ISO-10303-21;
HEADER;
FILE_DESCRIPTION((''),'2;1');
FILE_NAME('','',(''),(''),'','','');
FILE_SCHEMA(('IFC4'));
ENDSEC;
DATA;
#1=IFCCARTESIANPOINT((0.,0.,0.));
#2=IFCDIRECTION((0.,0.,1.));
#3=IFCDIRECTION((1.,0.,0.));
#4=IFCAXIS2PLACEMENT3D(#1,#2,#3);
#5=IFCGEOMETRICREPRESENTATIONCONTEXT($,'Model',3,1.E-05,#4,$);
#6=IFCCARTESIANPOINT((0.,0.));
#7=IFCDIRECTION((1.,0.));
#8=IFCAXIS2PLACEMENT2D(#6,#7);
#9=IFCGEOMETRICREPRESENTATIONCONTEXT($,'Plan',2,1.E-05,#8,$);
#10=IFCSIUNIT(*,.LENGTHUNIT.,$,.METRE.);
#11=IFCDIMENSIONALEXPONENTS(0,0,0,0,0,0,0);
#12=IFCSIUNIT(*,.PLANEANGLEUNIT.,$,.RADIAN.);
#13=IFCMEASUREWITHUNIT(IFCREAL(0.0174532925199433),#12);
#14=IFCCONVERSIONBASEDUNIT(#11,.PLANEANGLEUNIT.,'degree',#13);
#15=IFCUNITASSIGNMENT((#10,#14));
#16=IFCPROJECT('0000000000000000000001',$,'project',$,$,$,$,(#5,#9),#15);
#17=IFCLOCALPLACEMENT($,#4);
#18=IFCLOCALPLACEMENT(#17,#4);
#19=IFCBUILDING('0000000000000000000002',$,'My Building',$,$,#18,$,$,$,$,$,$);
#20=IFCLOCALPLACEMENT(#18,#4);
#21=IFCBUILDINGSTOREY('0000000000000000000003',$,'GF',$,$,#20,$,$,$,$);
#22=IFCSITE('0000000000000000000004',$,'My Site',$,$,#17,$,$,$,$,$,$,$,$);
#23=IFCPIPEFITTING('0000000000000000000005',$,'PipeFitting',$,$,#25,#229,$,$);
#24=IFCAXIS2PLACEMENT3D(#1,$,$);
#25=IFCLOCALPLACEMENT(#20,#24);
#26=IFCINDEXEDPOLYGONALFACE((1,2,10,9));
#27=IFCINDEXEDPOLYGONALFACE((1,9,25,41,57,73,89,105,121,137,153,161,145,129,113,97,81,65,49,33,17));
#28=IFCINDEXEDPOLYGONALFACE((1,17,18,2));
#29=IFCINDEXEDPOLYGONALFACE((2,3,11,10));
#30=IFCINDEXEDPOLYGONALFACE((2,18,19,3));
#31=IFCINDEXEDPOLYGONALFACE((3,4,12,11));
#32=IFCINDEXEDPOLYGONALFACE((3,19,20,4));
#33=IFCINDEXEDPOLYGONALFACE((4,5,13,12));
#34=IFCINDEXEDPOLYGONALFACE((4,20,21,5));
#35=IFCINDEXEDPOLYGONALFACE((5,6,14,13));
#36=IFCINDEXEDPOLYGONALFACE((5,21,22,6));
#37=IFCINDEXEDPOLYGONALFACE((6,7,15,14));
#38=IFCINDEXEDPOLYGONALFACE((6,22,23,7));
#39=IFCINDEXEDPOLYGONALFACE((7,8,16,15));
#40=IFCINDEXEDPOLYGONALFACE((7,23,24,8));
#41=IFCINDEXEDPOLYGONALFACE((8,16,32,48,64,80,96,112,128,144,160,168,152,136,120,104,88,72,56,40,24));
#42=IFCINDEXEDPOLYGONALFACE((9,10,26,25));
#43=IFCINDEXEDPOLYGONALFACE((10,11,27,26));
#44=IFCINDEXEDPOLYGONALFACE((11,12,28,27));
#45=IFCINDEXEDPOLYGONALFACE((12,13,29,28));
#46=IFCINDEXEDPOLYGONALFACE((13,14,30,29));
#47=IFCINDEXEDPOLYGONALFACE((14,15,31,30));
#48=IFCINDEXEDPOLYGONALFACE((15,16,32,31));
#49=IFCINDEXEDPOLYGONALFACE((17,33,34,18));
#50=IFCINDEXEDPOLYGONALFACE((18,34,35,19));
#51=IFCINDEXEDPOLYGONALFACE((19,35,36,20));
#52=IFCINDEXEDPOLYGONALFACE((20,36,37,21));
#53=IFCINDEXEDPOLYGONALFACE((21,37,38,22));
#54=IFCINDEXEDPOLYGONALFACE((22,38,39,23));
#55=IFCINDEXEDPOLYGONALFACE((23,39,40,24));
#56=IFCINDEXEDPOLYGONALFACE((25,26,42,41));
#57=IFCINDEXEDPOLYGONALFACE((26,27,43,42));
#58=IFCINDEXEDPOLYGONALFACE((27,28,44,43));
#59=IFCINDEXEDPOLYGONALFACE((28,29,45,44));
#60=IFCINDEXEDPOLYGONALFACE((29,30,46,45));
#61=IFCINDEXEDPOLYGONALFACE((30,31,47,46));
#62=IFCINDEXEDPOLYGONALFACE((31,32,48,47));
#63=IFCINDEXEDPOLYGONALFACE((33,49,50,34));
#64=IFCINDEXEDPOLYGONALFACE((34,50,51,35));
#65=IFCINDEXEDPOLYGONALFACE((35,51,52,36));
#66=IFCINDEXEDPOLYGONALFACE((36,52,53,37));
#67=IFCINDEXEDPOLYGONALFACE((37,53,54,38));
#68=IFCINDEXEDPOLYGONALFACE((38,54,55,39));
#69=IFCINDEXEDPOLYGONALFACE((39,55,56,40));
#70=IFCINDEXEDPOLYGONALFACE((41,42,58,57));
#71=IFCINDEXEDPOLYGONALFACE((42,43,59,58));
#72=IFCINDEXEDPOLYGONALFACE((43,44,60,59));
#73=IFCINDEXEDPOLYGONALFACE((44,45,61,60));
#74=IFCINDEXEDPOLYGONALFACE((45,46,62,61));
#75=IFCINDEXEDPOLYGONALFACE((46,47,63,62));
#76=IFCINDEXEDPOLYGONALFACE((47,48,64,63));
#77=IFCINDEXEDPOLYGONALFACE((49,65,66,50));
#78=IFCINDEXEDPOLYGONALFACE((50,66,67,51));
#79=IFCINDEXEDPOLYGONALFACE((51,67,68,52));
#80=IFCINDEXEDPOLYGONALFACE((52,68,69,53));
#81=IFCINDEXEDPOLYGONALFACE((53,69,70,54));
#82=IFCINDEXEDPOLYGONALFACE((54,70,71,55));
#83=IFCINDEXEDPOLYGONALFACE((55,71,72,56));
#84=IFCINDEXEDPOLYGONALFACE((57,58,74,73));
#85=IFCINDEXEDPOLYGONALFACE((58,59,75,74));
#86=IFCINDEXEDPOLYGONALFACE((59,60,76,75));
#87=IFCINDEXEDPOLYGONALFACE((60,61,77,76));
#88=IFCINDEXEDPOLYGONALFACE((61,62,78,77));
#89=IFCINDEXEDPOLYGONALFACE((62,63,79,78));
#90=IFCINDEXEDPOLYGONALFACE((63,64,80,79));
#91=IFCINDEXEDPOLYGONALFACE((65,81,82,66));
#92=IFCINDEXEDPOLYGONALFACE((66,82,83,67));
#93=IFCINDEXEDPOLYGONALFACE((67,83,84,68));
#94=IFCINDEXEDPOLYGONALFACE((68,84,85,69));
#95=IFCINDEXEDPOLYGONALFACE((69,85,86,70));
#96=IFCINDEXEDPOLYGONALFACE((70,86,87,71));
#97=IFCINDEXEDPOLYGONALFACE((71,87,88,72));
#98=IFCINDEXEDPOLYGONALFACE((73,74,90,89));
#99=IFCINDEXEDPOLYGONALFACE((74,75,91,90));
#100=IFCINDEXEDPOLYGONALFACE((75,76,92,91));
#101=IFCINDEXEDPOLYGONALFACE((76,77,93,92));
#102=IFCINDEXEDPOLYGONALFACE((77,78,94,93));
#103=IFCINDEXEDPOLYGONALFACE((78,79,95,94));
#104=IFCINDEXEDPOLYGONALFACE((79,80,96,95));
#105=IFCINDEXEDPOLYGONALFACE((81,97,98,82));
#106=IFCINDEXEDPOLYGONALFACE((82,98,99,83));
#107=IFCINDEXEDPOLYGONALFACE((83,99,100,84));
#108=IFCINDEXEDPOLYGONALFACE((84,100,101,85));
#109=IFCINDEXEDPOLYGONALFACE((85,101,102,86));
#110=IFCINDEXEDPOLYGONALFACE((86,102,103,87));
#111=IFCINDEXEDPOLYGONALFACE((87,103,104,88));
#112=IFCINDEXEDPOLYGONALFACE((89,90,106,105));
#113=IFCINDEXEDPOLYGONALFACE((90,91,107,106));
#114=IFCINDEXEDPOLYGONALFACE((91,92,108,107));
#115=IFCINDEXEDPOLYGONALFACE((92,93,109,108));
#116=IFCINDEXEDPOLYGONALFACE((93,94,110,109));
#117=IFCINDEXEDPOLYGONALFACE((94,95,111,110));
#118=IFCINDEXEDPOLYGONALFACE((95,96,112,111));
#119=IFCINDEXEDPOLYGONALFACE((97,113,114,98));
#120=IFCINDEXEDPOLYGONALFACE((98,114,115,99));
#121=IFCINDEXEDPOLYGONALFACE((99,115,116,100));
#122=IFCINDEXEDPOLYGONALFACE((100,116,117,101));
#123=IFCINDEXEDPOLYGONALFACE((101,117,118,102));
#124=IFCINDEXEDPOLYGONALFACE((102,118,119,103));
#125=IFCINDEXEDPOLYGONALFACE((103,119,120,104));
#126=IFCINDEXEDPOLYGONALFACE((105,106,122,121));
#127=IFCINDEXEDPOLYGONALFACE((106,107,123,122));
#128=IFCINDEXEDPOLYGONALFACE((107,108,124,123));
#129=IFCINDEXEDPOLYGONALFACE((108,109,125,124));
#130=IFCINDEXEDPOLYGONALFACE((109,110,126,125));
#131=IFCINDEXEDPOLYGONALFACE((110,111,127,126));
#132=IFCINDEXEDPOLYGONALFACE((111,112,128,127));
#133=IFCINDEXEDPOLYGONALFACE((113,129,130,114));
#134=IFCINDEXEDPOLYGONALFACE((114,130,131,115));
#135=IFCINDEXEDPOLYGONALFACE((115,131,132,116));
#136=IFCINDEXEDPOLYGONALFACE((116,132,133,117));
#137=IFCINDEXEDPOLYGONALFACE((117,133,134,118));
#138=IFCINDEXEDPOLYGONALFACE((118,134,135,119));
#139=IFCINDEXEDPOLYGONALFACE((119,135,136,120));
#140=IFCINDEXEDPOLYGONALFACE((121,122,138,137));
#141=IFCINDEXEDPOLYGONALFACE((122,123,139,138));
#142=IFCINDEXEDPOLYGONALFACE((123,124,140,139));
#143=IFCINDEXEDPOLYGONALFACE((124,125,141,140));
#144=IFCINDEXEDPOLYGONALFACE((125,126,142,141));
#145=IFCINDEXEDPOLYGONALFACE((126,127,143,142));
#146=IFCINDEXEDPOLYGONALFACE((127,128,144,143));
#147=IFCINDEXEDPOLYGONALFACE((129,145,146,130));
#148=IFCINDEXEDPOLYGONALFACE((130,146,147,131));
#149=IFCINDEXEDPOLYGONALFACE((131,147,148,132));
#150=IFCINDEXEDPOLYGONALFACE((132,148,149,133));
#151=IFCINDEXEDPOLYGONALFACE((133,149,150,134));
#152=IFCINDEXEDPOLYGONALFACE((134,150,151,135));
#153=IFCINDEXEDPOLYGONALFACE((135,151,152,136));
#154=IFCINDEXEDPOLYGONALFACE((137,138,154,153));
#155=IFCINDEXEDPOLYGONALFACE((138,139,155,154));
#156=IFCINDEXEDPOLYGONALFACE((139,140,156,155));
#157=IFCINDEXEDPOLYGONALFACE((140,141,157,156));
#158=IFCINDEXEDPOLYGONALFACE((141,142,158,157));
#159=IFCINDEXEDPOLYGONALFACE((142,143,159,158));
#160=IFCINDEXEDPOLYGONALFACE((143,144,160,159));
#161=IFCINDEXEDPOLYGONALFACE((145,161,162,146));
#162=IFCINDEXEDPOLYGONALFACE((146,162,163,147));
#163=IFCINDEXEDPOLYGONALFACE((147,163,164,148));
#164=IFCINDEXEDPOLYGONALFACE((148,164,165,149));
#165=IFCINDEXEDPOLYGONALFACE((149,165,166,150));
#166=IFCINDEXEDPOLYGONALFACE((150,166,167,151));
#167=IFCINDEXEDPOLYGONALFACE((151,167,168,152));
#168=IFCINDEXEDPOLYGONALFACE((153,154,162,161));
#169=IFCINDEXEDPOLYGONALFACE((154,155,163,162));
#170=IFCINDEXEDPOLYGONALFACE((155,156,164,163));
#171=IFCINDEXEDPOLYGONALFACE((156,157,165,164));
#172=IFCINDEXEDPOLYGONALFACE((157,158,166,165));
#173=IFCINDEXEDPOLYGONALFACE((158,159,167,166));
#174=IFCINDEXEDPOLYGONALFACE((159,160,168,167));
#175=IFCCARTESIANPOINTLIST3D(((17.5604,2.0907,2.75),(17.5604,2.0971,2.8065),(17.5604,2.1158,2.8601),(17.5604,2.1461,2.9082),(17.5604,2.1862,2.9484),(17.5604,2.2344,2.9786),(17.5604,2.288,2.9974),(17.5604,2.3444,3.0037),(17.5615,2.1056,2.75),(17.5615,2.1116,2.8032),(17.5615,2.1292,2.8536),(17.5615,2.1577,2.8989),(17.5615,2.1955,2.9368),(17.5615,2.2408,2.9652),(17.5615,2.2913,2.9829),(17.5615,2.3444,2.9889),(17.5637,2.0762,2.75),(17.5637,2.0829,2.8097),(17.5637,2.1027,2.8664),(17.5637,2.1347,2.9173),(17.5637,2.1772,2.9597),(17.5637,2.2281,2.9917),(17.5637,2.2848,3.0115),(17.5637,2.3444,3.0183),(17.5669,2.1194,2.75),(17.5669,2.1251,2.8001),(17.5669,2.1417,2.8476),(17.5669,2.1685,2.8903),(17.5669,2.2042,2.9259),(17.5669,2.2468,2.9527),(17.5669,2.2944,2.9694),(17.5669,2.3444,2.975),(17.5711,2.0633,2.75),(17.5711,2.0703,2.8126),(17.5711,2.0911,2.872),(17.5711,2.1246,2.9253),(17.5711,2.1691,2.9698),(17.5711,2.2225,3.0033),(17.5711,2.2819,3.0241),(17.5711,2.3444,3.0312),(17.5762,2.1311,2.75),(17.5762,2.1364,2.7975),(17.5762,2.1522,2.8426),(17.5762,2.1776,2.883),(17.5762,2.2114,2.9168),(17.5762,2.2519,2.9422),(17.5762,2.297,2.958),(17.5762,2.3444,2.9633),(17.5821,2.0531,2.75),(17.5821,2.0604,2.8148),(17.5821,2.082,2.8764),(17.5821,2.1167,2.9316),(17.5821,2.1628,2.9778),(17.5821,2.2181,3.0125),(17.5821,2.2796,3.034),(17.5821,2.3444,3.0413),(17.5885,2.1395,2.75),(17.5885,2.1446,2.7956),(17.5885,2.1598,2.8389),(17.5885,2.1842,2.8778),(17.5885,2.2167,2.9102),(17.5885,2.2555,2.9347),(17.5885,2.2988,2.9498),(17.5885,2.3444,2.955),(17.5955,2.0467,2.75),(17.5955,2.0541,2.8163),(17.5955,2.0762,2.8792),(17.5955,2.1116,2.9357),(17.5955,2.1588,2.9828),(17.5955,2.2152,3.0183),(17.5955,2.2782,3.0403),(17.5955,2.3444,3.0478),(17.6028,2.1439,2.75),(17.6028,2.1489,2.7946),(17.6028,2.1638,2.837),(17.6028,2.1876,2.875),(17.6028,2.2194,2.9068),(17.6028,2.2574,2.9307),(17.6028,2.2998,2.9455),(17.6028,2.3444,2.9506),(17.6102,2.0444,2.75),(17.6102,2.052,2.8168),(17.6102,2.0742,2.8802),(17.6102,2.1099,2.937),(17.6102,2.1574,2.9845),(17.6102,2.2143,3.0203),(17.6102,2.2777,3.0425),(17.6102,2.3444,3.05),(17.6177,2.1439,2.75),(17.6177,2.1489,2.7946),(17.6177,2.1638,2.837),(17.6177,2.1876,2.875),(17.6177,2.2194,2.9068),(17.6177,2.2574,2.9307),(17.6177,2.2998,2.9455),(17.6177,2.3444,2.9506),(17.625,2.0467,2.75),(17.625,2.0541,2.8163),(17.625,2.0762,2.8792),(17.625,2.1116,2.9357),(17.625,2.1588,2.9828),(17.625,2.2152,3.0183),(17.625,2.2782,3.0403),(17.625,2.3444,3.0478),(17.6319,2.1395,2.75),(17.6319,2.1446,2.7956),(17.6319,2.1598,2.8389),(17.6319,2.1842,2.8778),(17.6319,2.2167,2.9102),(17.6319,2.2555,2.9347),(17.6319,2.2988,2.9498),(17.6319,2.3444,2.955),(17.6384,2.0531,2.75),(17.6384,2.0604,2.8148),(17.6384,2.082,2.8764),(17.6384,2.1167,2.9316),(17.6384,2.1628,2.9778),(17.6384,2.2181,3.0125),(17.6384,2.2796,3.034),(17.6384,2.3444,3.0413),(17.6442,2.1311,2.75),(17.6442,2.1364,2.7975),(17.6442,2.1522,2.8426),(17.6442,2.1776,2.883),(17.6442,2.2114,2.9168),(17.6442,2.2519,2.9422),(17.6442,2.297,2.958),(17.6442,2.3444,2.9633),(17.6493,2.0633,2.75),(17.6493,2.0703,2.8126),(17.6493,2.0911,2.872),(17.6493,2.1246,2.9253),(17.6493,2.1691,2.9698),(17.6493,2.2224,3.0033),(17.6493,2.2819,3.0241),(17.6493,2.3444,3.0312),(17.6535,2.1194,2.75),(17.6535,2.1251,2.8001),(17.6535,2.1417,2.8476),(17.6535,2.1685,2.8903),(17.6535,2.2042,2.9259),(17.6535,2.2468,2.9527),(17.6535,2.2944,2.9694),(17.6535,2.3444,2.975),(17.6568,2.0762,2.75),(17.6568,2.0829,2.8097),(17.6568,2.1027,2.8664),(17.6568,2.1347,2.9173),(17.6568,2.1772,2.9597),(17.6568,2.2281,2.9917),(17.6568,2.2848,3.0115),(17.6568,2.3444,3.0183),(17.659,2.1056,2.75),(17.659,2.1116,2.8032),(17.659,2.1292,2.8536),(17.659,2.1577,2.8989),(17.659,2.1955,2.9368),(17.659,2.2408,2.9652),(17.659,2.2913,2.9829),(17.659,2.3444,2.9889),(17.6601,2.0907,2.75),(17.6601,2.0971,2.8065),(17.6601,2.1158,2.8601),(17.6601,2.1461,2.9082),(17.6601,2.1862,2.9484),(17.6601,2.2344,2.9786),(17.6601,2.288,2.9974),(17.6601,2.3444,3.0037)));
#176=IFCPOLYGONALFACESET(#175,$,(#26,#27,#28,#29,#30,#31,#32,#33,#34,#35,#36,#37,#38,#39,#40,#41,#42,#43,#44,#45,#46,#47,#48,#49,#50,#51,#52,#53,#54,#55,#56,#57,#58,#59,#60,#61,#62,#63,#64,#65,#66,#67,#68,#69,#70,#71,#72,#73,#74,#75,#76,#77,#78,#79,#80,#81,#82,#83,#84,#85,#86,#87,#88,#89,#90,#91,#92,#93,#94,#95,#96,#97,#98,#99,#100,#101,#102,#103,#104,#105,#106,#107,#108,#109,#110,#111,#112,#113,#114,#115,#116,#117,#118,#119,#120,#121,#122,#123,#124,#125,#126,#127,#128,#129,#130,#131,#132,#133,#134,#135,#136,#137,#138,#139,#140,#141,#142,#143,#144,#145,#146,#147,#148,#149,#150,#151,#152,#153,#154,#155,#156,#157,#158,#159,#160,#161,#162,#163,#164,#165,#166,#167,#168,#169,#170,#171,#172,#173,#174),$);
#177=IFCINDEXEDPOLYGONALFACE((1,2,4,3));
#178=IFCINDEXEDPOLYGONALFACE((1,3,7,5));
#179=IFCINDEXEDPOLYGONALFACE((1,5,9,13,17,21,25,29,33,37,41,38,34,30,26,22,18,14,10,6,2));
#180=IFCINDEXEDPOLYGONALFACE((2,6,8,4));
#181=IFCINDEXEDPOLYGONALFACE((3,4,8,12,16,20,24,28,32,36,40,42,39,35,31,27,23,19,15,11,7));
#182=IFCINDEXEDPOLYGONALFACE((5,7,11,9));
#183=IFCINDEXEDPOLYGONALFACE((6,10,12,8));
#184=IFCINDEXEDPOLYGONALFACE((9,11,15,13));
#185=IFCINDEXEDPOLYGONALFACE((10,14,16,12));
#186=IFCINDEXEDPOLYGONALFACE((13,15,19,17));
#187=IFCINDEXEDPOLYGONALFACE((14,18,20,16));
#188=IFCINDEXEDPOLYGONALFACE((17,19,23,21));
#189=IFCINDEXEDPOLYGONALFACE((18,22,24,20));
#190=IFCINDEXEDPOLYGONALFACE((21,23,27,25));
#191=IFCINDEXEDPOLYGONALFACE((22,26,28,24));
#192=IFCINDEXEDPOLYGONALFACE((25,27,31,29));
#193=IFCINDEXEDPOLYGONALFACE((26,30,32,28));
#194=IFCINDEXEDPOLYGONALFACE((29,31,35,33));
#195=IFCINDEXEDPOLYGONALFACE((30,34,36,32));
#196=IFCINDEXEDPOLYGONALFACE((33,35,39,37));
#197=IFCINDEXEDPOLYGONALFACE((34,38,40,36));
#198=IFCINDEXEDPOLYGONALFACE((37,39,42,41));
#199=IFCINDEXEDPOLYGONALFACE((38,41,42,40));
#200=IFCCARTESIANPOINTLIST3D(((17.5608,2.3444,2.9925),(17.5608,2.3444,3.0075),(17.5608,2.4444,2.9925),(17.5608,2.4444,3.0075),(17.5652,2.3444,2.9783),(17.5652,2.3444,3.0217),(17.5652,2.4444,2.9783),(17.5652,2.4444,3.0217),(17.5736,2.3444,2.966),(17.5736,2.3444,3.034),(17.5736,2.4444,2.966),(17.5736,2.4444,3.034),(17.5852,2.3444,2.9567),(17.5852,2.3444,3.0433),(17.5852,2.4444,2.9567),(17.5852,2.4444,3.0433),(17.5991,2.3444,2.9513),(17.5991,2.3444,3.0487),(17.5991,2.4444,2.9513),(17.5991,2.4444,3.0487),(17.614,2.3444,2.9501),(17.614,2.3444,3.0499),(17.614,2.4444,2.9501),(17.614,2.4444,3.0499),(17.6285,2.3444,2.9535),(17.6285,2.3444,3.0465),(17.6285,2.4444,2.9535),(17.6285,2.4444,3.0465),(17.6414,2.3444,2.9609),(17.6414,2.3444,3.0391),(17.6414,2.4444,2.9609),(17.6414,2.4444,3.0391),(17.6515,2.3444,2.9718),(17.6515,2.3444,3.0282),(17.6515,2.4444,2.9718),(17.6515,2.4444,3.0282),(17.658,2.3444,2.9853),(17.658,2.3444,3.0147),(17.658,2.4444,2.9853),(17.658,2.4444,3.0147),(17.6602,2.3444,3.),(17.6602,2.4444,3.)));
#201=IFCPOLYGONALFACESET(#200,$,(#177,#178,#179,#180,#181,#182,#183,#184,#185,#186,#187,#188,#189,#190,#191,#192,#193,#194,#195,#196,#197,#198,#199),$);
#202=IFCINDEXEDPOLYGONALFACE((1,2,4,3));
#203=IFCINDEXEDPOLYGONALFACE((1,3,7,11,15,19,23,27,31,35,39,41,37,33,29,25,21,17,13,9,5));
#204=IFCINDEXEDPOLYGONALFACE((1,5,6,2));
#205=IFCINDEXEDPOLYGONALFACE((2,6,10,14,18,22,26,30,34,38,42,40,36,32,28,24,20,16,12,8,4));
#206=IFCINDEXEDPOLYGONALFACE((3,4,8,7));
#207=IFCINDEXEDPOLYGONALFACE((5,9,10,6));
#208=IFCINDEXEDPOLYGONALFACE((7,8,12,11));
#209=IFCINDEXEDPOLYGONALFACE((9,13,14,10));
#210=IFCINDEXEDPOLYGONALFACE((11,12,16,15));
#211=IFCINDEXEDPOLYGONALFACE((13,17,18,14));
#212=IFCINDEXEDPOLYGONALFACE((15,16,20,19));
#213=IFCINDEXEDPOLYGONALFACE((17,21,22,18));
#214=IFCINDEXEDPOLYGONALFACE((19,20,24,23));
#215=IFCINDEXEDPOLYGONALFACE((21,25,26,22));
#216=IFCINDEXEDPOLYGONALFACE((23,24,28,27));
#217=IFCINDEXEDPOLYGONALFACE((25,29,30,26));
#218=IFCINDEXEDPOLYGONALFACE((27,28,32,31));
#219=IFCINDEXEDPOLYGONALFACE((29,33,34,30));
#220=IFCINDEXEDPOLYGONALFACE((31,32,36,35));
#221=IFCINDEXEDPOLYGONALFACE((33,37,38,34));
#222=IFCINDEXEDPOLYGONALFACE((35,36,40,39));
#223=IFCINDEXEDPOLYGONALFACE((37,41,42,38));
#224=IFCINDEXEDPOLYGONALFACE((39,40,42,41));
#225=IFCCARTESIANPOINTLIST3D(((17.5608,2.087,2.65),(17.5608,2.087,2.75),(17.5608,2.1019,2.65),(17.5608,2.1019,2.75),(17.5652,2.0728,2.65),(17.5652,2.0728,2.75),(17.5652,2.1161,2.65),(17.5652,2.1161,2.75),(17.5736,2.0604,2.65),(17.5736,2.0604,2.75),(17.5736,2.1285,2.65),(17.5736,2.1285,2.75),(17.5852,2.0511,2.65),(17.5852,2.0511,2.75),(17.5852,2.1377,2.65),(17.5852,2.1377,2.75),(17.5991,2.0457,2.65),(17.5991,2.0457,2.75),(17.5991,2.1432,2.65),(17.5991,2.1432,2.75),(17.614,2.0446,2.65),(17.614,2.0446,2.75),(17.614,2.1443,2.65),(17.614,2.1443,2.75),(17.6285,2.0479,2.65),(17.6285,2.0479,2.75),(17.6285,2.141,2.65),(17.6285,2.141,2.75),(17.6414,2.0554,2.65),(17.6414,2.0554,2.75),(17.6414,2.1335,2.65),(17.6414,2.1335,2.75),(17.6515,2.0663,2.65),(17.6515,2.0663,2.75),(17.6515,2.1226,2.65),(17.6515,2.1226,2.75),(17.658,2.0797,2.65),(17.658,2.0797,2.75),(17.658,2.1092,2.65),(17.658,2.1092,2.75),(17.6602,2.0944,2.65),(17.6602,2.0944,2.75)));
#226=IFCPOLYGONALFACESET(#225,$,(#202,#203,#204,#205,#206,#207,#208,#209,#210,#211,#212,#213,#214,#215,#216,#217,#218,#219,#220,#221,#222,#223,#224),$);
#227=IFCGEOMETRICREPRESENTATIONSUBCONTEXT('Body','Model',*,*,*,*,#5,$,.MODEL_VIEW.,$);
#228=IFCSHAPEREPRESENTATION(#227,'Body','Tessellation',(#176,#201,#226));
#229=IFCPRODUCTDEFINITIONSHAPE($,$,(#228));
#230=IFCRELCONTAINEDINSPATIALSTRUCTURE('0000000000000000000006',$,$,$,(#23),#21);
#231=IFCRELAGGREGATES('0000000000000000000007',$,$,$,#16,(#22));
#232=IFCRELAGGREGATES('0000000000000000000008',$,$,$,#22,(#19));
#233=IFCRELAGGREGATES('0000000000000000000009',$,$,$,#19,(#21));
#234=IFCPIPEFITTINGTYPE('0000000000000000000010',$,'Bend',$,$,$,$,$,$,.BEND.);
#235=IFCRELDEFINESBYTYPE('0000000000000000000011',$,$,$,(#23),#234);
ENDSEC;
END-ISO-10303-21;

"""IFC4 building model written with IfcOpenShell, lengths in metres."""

from ifc_helpers import new_model, entity, si_unit, converted_unit, frame, origin_with_axes, origin_2d_with_axis, place, context, subcontext, project, spatial, circle, extrude, source, transform, mapped, type_object, type_shapes, element, save


model = new_model("IFC4")

# Units and contexts
model_context = context("Model", 3, precision=1e-05, world=origin_with_axes())
plan_context = context("Plan", 2, precision=1e-05, world=origin_2d_with_axis())
body_context_1 = subcontext(model_context, "Body", "Model", "MODEL_VIEW")
ifc_project = project(units=[si_unit("LENGTHUNIT", "METRE"), converted_unit("PLANEANGLEUNIT", "degree", entity("IfcReal", 0.0174532925199433), si_unit("PLANEANGLEUNIT", "RADIAN"), dimensions=[0, 0, 0, 0, 0, 0, 0])], contexts=[model_context, plan_context])

# Site, building, storey
site_placement = place(None, origin_with_axes())
site = spatial("IfcSite", under=ifc_project, at=site_placement, Name="My Site")
building_placement = place(site_placement, origin_with_axes())
building = spatial("IfcBuilding", under=site, at=building_placement, Name="My Building")
storey_placement = place(building_placement, origin_with_axes())
storey = spatial("IfcBuildingStorey", under=building, at=storey_placement, Name="GF")

# Pipe fitting
pipe_fitting_type = type_object("IfcPipeFittingType", Name="Bend", PredefinedType="BEND")
shared_shape_1 = source(origin_with_axes(), body_context_1, "Body", "SolidModel", [
    entity("IfcSweptDiskSolid", entity("IfcIndexedPolyCurve", entity("IfcCartesianPointList3D", [[0.0, 0.0, 0.1], [0.0, -0.0732, 0.2768], [0.0, -0.25, 0.35]]), [entity("IfcArcIndex", [1, 2, 3])]), 0.05),
    extrude(circle(Radius=0.05), origin_with_axes(), (0.0, 0.0, 1.0), 0.1),
    extrude(circle(Radius=0.05), frame((0.0, -0.25, 0.35), z_axis=(0.0, -1.0, 0.0), x_axis=(1.0, 0.0, 0.0)), (0.0, 0.0, 1.0), 0.1),
])
type_shapes(pipe_fitting_type, [shared_shape_1])
for number, where, z_axis, x_axis, name in (
    (1, (17.6102, 2.4444, 3.0), (0.0, -1.0, 0.0), (1.0, 0.0, 0.0), "PipeFitting"),
):
    element("IfcPipeFitting", number, at=place(storey_placement, frame(where, z_axis=z_axis, x_axis=x_axis)), inside=storey, type_object=pipe_fitting_type, Name=name, context=body_context_1, shape_type="MappedRepresentation", body=[
        mapped(shared_shape_1, transform((0.0, 0.0, 0.0), x_axis=(1.0, 0.0, 0.0), y_axis=(0.0, 1.0, 0.0), z_axis=(0.0, 0.0, 1.0), scale=1.0)),
    ])

save(model, "model.ifc")
